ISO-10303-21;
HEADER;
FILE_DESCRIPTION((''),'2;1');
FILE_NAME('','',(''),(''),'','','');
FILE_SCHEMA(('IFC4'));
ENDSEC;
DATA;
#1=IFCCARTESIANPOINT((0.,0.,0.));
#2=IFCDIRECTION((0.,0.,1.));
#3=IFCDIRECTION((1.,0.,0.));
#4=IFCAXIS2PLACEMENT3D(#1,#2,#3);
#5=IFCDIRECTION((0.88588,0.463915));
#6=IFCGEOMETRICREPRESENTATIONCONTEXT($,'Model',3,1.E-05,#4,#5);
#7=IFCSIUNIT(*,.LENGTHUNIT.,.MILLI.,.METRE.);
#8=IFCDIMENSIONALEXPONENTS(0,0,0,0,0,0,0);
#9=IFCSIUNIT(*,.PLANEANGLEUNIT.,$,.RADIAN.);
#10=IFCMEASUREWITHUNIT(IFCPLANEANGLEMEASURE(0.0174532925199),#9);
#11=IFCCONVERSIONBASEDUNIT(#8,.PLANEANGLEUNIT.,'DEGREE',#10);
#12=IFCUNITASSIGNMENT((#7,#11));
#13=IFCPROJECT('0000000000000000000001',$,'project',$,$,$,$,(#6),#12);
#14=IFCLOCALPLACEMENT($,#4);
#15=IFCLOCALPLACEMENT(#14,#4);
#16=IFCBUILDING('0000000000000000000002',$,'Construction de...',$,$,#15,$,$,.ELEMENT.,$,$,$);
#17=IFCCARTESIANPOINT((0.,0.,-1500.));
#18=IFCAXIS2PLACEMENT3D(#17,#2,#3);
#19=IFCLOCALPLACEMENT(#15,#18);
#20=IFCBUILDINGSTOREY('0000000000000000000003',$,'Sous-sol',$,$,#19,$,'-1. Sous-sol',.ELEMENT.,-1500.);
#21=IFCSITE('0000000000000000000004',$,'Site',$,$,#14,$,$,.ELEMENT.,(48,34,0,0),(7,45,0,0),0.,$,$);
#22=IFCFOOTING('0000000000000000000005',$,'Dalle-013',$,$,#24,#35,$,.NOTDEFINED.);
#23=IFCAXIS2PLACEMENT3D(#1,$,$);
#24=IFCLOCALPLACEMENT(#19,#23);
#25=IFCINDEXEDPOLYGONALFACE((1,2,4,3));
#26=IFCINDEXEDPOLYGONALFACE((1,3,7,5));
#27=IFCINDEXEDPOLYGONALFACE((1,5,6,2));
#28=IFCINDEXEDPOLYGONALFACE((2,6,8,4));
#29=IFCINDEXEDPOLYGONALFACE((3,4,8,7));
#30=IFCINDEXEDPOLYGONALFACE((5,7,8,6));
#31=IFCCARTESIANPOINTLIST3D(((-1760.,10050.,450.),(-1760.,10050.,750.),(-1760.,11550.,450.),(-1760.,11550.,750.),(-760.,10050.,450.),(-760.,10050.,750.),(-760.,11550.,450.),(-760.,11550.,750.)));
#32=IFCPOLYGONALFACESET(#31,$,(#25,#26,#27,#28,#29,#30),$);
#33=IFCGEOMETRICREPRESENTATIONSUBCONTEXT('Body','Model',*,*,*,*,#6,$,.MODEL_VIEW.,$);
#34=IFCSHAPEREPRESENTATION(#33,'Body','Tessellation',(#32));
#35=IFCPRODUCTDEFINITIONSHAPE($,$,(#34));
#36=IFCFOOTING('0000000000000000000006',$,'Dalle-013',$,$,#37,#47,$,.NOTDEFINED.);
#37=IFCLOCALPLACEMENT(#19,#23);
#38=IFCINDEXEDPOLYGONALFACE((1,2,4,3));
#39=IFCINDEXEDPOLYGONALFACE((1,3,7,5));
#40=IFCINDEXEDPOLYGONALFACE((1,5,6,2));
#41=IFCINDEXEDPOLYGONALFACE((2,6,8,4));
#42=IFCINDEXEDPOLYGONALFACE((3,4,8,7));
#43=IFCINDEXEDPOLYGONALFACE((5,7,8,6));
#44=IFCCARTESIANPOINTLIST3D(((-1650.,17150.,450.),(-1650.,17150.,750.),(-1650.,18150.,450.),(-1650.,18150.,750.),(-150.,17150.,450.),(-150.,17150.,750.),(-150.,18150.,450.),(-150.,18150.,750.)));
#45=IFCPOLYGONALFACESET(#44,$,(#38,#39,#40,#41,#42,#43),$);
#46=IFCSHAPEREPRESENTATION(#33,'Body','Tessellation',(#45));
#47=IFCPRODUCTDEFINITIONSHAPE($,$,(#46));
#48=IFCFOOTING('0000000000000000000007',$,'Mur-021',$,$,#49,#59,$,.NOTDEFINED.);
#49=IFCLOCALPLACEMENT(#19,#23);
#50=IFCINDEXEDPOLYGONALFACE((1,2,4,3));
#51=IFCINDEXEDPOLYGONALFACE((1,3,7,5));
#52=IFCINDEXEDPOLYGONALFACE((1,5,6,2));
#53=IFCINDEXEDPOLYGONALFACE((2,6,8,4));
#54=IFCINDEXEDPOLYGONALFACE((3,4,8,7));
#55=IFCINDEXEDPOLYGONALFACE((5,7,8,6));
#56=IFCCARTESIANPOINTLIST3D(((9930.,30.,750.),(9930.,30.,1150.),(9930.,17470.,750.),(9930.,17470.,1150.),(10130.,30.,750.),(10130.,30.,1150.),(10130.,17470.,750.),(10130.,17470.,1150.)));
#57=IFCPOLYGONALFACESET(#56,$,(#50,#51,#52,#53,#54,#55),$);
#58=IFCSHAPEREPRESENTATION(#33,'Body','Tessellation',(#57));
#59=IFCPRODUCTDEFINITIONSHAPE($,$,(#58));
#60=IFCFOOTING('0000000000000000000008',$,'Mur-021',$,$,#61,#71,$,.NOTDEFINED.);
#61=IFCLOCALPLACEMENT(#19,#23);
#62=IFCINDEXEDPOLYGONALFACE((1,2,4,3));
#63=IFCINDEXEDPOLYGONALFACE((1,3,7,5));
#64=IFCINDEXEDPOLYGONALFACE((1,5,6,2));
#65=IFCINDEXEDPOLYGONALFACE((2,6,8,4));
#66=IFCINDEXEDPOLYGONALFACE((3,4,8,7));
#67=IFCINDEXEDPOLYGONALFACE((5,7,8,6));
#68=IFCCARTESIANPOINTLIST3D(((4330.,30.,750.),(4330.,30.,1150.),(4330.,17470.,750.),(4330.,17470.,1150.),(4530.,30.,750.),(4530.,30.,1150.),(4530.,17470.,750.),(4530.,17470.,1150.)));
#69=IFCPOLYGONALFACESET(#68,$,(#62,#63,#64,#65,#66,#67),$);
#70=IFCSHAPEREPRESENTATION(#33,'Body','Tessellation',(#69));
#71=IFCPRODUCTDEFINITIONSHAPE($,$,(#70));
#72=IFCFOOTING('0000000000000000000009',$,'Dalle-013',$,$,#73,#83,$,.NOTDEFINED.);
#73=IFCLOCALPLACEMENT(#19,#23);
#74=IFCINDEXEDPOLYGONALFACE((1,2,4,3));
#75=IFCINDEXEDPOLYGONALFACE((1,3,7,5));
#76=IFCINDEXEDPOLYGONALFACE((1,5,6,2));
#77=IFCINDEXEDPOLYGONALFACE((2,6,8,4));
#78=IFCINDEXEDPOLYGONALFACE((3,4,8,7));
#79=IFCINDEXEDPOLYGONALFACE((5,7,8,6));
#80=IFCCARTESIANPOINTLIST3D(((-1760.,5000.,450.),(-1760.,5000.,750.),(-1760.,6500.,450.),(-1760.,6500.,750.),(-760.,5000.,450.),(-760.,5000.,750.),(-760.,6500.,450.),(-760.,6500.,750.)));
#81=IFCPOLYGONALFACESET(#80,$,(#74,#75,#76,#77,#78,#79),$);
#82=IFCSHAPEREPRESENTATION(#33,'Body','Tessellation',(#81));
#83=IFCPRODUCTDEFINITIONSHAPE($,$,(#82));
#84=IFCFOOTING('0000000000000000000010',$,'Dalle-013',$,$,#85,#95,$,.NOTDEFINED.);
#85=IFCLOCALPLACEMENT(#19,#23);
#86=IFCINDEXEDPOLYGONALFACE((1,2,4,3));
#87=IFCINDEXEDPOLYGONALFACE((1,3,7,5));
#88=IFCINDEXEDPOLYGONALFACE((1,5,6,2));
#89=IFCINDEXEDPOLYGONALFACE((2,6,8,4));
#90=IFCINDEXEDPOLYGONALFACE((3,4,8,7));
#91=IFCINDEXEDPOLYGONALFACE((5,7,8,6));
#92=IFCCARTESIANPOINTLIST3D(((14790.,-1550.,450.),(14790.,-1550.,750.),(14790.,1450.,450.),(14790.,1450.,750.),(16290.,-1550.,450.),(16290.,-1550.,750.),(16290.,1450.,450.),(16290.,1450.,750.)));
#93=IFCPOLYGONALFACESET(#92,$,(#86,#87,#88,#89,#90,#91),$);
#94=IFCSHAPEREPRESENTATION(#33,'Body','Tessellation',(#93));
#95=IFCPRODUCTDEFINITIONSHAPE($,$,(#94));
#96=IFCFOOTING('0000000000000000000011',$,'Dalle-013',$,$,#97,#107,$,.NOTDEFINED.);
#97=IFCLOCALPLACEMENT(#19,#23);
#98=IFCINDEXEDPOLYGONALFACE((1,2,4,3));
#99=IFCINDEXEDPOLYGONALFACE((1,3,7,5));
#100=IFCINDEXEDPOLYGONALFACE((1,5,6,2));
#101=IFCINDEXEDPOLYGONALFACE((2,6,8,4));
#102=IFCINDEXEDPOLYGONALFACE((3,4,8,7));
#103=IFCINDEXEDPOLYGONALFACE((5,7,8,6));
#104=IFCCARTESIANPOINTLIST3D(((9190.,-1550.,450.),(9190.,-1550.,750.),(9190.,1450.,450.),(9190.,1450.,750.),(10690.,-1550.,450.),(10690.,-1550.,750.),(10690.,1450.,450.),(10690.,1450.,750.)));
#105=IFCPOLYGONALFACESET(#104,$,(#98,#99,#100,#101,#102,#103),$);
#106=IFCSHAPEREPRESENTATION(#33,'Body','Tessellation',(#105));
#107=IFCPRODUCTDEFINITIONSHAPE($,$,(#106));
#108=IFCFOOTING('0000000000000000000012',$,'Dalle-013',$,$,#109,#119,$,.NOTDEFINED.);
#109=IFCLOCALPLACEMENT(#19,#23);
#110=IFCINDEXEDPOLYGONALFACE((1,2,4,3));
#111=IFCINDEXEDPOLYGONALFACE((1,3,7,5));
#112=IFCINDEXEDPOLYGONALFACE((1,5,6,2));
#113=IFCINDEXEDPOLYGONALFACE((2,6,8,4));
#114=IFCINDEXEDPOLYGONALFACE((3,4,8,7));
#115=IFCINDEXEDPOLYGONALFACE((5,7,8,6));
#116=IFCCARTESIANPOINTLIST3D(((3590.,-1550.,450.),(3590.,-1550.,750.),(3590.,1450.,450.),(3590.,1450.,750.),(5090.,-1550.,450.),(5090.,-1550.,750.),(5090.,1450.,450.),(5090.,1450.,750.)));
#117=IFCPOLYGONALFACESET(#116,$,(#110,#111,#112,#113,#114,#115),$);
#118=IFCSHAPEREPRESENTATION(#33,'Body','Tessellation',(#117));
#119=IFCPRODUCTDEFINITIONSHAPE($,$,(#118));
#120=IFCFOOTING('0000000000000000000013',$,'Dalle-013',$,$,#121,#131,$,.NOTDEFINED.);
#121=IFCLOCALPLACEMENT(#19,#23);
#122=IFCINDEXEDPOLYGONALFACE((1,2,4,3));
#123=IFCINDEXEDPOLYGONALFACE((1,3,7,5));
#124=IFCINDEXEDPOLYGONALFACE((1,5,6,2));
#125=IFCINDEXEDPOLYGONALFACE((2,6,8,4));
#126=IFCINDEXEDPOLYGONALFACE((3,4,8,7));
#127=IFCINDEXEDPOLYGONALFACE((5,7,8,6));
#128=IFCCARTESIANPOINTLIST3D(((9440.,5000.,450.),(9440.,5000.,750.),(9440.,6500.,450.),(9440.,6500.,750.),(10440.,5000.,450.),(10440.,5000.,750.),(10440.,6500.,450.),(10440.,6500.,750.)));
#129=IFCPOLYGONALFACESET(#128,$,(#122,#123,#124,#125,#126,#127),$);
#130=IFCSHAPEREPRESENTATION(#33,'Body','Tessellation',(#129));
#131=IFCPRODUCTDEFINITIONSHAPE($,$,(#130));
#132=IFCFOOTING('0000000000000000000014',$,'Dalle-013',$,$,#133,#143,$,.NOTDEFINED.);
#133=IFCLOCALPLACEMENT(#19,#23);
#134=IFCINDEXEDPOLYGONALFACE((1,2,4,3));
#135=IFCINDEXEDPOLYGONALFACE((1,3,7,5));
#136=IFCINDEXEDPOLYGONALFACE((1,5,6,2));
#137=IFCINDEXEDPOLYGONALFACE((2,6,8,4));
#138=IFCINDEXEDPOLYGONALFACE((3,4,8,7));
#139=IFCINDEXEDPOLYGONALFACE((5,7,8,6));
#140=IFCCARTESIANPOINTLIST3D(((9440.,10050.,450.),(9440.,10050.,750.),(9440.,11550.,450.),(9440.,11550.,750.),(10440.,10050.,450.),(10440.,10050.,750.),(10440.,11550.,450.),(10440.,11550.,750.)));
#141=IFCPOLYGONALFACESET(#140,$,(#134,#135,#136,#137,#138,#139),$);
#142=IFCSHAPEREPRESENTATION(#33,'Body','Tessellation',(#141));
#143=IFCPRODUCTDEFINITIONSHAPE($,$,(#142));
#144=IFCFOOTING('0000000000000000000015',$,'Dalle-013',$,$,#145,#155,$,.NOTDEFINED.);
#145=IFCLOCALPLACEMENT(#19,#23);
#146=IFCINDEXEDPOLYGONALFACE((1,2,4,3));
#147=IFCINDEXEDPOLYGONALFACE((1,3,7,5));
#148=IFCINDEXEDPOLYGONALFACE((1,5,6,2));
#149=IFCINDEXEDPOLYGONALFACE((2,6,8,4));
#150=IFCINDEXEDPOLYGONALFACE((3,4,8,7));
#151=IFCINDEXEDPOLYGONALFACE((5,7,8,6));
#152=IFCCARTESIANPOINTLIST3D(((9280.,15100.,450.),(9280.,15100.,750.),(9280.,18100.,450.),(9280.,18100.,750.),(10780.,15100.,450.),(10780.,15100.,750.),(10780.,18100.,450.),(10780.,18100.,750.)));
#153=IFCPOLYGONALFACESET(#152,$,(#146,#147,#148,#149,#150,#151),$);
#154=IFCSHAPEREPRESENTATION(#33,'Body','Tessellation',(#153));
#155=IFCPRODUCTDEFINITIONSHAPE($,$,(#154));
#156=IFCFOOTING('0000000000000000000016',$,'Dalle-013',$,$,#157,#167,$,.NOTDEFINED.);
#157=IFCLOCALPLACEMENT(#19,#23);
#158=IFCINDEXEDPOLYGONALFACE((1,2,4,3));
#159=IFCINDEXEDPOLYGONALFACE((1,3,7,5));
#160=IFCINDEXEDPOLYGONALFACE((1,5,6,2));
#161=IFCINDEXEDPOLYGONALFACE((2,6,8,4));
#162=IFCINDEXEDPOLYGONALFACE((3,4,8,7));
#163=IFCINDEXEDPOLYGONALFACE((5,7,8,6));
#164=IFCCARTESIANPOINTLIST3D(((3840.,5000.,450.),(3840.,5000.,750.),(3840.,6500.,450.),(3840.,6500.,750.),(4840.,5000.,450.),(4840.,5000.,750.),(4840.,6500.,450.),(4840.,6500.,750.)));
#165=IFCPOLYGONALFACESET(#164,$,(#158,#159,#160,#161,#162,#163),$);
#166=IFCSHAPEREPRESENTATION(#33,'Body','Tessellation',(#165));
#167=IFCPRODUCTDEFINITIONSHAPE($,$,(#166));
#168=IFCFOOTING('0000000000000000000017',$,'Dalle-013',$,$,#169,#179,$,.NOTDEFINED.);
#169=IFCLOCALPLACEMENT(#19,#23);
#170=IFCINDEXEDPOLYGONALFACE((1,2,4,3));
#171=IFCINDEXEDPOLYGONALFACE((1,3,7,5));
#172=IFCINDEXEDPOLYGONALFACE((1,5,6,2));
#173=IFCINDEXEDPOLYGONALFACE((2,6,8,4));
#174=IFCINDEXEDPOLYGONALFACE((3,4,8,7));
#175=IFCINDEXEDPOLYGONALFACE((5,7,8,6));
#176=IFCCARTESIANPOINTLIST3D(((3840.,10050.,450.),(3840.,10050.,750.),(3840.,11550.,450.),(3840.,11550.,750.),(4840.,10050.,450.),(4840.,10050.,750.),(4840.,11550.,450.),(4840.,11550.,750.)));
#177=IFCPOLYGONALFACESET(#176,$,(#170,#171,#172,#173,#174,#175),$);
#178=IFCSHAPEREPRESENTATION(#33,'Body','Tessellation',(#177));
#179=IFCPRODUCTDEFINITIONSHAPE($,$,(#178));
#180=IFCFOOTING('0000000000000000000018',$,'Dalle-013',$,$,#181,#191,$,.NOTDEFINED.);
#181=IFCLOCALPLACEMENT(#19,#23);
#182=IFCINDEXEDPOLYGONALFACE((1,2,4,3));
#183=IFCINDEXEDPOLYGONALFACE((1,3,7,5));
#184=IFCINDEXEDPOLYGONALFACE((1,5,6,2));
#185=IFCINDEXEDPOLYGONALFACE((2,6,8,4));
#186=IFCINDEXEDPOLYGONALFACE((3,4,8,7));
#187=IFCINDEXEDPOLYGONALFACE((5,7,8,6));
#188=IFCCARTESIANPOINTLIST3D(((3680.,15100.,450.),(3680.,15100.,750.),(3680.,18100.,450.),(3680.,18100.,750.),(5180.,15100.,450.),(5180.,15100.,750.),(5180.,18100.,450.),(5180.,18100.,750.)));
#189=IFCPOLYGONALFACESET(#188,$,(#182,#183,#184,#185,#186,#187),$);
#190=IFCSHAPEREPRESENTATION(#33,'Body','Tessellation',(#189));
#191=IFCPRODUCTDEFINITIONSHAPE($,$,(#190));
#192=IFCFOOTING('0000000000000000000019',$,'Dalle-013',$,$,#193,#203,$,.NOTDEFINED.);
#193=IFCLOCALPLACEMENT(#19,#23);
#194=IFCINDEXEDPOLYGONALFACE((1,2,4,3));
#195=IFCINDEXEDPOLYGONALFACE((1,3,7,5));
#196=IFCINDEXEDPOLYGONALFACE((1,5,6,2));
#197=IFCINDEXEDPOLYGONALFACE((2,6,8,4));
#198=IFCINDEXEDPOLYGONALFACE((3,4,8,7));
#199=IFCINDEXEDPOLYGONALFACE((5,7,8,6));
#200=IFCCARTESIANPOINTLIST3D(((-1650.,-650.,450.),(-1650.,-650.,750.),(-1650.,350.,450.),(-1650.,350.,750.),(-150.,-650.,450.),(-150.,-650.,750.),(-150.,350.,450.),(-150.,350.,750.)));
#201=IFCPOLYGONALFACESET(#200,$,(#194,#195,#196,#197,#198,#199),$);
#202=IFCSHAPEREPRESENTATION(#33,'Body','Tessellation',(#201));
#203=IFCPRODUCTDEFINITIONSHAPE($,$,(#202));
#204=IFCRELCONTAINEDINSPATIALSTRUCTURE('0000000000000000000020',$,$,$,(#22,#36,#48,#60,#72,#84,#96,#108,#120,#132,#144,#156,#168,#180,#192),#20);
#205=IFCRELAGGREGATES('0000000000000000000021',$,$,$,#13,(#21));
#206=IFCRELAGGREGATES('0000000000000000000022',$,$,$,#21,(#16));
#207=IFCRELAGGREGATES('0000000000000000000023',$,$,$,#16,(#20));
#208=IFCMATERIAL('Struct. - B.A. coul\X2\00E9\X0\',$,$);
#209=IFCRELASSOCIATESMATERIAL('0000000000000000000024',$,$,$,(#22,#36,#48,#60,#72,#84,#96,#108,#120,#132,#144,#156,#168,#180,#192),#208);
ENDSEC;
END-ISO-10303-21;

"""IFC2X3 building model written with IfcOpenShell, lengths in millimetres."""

from ifc_helpers import new_model, entity, si_unit, converted_unit, direction, frame, origin_with_axes, place, context, subcontext, project, spatial, polyline, outline, extrude, material, element, save


model = new_model("IFC2X3")

# Units and contexts
model_context = context("Model", 3, precision=1e-05, world=origin_with_axes(), true_north=direction((0.88588, 0.463915)))
body_context = subcontext(model_context, "Body", "Model", "MODEL_VIEW")
ifc_project = project(units=[si_unit("LENGTHUNIT", "METRE", prefix="MILLI"), converted_unit("PLANEANGLEUNIT", "DEGREE", entity("IfcPlaneAngleMeasure", 0.0174532925199), si_unit("PLANEANGLEUNIT", "RADIAN"), dimensions=[0, 0, 0, 0, 0, 0, 0])], contexts=[model_context])

# Site, building, storey
site_placement = place(None, origin_with_axes())
site = spatial("IfcSite", under=ifc_project, at=site_placement, Name="Site", CompositionType="ELEMENT", RefLatitude=(48, 34, 0, 0), RefLongitude=(7, 45, 0, 0), RefElevation=0.0)
building_placement = place(site_placement, origin_with_axes())
building = spatial("IfcBuilding", under=site, at=building_placement, Name="Construction de...", CompositionType="ELEMENT")
storey_placement = place(building_placement, frame((0.0, 0.0, -1500.0), z_axis=(0.0, 0.0, 1.0), x_axis=(1.0, 0.0, 0.0)))
storey = spatial("IfcBuildingStorey", under=building, at=storey_placement, Name="Sous-sol", LongName="-1. Sous-sol", CompositionType="ELEMENT", Elevation=-1500.0)

# Footings
ifc_material_1 = material(Name="Struct. - B.A. coulé")
footing_1_placement = place(storey_placement, frame((-1760.0, 11550.0, 750.0), z_axis=(0.0, 0.0, 1.0), x_axis=(1.0, 0.0, 0.0)))
element("IfcFooting", 1, at=footing_1_placement, inside=storey, material=ifc_material_1, Name="Dalle-013", PredefinedType="NOTDEFINED", context=body_context, shape_type="SweptSolid", body=[
    extrude(outline(polyline([(0.0, 0.0), (0.0, -1500.0), (1000.0, -1500.0), (1000.0, 0.0), (0.0, 0.0)])), frame((0.0, 0.0, -300.0), z_axis=(0.0, 0.0, 1.0), x_axis=(1.0, 0.0, 0.0)), (0.0, 0.0, 1.0), 300.0),
])
footing_2_placement = place(storey_placement, frame((-150.0, 18150.0, 750.0), z_axis=(0.0, 0.0, 1.0), x_axis=(1.0, 0.0, 0.0)))
element("IfcFooting", 2, at=footing_2_placement, inside=storey, material=ifc_material_1, Name="Dalle-013", PredefinedType="NOTDEFINED", context=body_context, shape_type="SweptSolid", body=[
    extrude(outline(polyline([(0.0, 0.0), (-1500.0, 0.0), (-1500.0, -1000.0), (0.0, -1000.0), (0.0, 0.0)])), frame((0.0, 0.0, -300.0), z_axis=(0.0, 0.0, 1.0), x_axis=(1.0, 0.0, 0.0)), (0.0, 0.0, 1.0), 300.0),
])
footing_3_placement = place(storey_placement, frame((10030.0, 17570.0, 750.0), z_axis=(0.0, 0.0, 1.0), x_axis=(0.0, -1.0, 0.0)))
element("IfcFooting", 3, at=footing_3_placement, inside=storey, material=ifc_material_1, Name="Mur-021", PredefinedType="NOTDEFINED", context=body_context, shape_type="SweptSolid", body=[
    extrude(outline(polyline([(100.0, -100.0), (17540.0, -100.0), (17540.0, 100.0), (100.0, 100.0), (100.0, -100.0)])), origin_with_axes(), (0.0, 0.0, 1.0), 400.0),
])
footing_4_placement = place(storey_placement, frame((4430.0, -70.0, 750.0), z_axis=(0.0, 0.0, 1.0), x_axis=(0.0, 1.0, 0.0)))
element("IfcFooting", 4, at=footing_4_placement, inside=storey, material=ifc_material_1, Name="Mur-021", PredefinedType="NOTDEFINED", context=body_context, shape_type="SweptSolid", body=[
    extrude(outline(polyline([(100.0, -100.0), (17540.0, -100.0), (17540.0, 100.0), (100.0, 100.0), (100.0, -100.0)])), origin_with_axes(), (0.0, 0.0, 1.0), 400.0),
])
footing_5_placement = place(storey_placement, frame((-1760.0, 6500.0, 750.0), z_axis=(0.0, 0.0, 1.0), x_axis=(1.0, 0.0, 0.0)))
element("IfcFooting", 5, at=footing_5_placement, inside=storey, material=ifc_material_1, Name="Dalle-013", PredefinedType="NOTDEFINED", context=body_context, shape_type="SweptSolid", body=[
    extrude(outline(polyline([(0.0, 0.0), (0.0, -1500.0), (1000.0, -1500.0), (1000.0, 0.0), (0.0, 0.0)])), frame((0.0, 0.0, -300.0), z_axis=(0.0, 0.0, 1.0), x_axis=(1.0, 0.0, 0.0)), (0.0, 0.0, 1.0), 300.0),
])
for number, where, z_axis, x_axis, name in (
    (6, (14790.0, 1450.0, 750.0), (0.0, 0.0, 1.0), (1.0, 0.0, 0.0), "Dalle-013"),
    (7, (9190.0, 1450.0, 750.0), (0.0, 0.0, 1.0), (1.0, 0.0, 0.0), "Dalle-013"),
    (8, (3590.0, 1450.0, 750.0), (0.0, 0.0, 1.0), (1.0, 0.0, 0.0), "Dalle-013"),
):
    element("IfcFooting", number, at=place(storey_placement, frame(where, z_axis=z_axis, x_axis=x_axis)), inside=storey, material=ifc_material_1, Name=name, PredefinedType="NOTDEFINED", context=body_context, shape_type="SweptSolid", body=[
        extrude(outline(polyline([(0.0, 0.0), (0.0, -3000.0), (1500.0, -3000.0), (1500.0, 0.0), (0.0, 0.0)])), frame((0.0, 0.0, -300.0), z_axis=(0.0, 0.0, 1.0), x_axis=(1.0, 0.0, 0.0)), (0.0, 0.0, 1.0), 300.0),
    ])
for number, where, z_axis, x_axis, name in (
    (9, (9440.0, 6500.0, 750.0), (0.0, 0.0, 1.0), (1.0, 0.0, 0.0), "Dalle-013"),
    (10, (9440.0, 11550.0, 750.0), (0.0, 0.0, 1.0), (1.0, 0.0, 0.0), "Dalle-013"),
):
    element("IfcFooting", number, at=place(storey_placement, frame(where, z_axis=z_axis, x_axis=x_axis)), inside=storey, material=ifc_material_1, Name=name, PredefinedType="NOTDEFINED", context=body_context, shape_type="SweptSolid", body=[
        extrude(outline(polyline([(0.0, 0.0), (0.0, -1500.0), (1000.0, -1500.0), (1000.0, 0.0), (0.0, 0.0)])), frame((0.0, 0.0, -300.0), z_axis=(0.0, 0.0, 1.0), x_axis=(1.0, 0.0, 0.0)), (0.0, 0.0, 1.0), 300.0),
    ])
footing_6_placement = place(storey_placement, frame((9280.0, 18100.0, 750.0), z_axis=(0.0, 0.0, 1.0), x_axis=(1.0, 0.0, 0.0)))
element("IfcFooting", 11, at=footing_6_placement, inside=storey, material=ifc_material_1, Name="Dalle-013", PredefinedType="NOTDEFINED", context=body_context, shape_type="SweptSolid", body=[
    extrude(outline(polyline([(0.0, 0.0), (0.0, -3000.0), (1500.0, -3000.0), (1500.0, 0.0), (0.0, 0.0)])), frame((0.0, 0.0, -300.0), z_axis=(0.0, 0.0, 1.0), x_axis=(1.0, 0.0, 0.0)), (0.0, 0.0, 1.0), 300.0),
])
for number, where, z_axis, x_axis, name in (
    (12, (3840.0, 6500.0, 750.0), (0.0, 0.0, 1.0), (1.0, 0.0, 0.0), "Dalle-013"),
    (13, (3840.0, 11550.0, 750.0), (0.0, 0.0, 1.0), (1.0, 0.0, 0.0), "Dalle-013"),
):
    element("IfcFooting", number, at=place(storey_placement, frame(where, z_axis=z_axis, x_axis=x_axis)), inside=storey, material=ifc_material_1, Name=name, PredefinedType="NOTDEFINED", context=body_context, shape_type="SweptSolid", body=[
        extrude(outline(polyline([(0.0, 0.0), (0.0, -1500.0), (1000.0, -1500.0), (1000.0, 0.0), (0.0, 0.0)])), frame((0.0, 0.0, -300.0), z_axis=(0.0, 0.0, 1.0), x_axis=(1.0, 0.0, 0.0)), (0.0, 0.0, 1.0), 300.0),
    ])
footing_7_placement = place(storey_placement, frame((3680.0, 18100.0, 750.0), z_axis=(0.0, 0.0, 1.0), x_axis=(1.0, 0.0, 0.0)))
element("IfcFooting", 14, at=footing_7_placement, inside=storey, material=ifc_material_1, Name="Dalle-013", PredefinedType="NOTDEFINED", context=body_context, shape_type="SweptSolid", body=[
    extrude(outline(polyline([(0.0, 0.0), (0.0, -3000.0), (1500.0, -3000.0), (1500.0, 0.0), (0.0, 0.0)])), frame((0.0, 0.0, -300.0), z_axis=(0.0, 0.0, 1.0), x_axis=(1.0, 0.0, 0.0)), (0.0, 0.0, 1.0), 300.0),
])
footing_8_placement = place(storey_placement, frame((-150.0, 350.0, 750.0), z_axis=(0.0, 0.0, 1.0), x_axis=(1.0, 0.0, 0.0)))
element("IfcFooting", 15, at=footing_8_placement, inside=storey, material=ifc_material_1, Name="Dalle-013", PredefinedType="NOTDEFINED", context=body_context, shape_type="SweptSolid", body=[
    extrude(outline(polyline([(0.0, 0.0), (-1500.0, 0.0), (-1500.0, -1000.0), (0.0, -1000.0), (0.0, 0.0)])), frame((0.0, 0.0, -300.0), z_axis=(0.0, 0.0, 1.0), x_axis=(1.0, 0.0, 0.0)), (0.0, 0.0, 1.0), 300.0),
])

save(model, "model.ifc")
